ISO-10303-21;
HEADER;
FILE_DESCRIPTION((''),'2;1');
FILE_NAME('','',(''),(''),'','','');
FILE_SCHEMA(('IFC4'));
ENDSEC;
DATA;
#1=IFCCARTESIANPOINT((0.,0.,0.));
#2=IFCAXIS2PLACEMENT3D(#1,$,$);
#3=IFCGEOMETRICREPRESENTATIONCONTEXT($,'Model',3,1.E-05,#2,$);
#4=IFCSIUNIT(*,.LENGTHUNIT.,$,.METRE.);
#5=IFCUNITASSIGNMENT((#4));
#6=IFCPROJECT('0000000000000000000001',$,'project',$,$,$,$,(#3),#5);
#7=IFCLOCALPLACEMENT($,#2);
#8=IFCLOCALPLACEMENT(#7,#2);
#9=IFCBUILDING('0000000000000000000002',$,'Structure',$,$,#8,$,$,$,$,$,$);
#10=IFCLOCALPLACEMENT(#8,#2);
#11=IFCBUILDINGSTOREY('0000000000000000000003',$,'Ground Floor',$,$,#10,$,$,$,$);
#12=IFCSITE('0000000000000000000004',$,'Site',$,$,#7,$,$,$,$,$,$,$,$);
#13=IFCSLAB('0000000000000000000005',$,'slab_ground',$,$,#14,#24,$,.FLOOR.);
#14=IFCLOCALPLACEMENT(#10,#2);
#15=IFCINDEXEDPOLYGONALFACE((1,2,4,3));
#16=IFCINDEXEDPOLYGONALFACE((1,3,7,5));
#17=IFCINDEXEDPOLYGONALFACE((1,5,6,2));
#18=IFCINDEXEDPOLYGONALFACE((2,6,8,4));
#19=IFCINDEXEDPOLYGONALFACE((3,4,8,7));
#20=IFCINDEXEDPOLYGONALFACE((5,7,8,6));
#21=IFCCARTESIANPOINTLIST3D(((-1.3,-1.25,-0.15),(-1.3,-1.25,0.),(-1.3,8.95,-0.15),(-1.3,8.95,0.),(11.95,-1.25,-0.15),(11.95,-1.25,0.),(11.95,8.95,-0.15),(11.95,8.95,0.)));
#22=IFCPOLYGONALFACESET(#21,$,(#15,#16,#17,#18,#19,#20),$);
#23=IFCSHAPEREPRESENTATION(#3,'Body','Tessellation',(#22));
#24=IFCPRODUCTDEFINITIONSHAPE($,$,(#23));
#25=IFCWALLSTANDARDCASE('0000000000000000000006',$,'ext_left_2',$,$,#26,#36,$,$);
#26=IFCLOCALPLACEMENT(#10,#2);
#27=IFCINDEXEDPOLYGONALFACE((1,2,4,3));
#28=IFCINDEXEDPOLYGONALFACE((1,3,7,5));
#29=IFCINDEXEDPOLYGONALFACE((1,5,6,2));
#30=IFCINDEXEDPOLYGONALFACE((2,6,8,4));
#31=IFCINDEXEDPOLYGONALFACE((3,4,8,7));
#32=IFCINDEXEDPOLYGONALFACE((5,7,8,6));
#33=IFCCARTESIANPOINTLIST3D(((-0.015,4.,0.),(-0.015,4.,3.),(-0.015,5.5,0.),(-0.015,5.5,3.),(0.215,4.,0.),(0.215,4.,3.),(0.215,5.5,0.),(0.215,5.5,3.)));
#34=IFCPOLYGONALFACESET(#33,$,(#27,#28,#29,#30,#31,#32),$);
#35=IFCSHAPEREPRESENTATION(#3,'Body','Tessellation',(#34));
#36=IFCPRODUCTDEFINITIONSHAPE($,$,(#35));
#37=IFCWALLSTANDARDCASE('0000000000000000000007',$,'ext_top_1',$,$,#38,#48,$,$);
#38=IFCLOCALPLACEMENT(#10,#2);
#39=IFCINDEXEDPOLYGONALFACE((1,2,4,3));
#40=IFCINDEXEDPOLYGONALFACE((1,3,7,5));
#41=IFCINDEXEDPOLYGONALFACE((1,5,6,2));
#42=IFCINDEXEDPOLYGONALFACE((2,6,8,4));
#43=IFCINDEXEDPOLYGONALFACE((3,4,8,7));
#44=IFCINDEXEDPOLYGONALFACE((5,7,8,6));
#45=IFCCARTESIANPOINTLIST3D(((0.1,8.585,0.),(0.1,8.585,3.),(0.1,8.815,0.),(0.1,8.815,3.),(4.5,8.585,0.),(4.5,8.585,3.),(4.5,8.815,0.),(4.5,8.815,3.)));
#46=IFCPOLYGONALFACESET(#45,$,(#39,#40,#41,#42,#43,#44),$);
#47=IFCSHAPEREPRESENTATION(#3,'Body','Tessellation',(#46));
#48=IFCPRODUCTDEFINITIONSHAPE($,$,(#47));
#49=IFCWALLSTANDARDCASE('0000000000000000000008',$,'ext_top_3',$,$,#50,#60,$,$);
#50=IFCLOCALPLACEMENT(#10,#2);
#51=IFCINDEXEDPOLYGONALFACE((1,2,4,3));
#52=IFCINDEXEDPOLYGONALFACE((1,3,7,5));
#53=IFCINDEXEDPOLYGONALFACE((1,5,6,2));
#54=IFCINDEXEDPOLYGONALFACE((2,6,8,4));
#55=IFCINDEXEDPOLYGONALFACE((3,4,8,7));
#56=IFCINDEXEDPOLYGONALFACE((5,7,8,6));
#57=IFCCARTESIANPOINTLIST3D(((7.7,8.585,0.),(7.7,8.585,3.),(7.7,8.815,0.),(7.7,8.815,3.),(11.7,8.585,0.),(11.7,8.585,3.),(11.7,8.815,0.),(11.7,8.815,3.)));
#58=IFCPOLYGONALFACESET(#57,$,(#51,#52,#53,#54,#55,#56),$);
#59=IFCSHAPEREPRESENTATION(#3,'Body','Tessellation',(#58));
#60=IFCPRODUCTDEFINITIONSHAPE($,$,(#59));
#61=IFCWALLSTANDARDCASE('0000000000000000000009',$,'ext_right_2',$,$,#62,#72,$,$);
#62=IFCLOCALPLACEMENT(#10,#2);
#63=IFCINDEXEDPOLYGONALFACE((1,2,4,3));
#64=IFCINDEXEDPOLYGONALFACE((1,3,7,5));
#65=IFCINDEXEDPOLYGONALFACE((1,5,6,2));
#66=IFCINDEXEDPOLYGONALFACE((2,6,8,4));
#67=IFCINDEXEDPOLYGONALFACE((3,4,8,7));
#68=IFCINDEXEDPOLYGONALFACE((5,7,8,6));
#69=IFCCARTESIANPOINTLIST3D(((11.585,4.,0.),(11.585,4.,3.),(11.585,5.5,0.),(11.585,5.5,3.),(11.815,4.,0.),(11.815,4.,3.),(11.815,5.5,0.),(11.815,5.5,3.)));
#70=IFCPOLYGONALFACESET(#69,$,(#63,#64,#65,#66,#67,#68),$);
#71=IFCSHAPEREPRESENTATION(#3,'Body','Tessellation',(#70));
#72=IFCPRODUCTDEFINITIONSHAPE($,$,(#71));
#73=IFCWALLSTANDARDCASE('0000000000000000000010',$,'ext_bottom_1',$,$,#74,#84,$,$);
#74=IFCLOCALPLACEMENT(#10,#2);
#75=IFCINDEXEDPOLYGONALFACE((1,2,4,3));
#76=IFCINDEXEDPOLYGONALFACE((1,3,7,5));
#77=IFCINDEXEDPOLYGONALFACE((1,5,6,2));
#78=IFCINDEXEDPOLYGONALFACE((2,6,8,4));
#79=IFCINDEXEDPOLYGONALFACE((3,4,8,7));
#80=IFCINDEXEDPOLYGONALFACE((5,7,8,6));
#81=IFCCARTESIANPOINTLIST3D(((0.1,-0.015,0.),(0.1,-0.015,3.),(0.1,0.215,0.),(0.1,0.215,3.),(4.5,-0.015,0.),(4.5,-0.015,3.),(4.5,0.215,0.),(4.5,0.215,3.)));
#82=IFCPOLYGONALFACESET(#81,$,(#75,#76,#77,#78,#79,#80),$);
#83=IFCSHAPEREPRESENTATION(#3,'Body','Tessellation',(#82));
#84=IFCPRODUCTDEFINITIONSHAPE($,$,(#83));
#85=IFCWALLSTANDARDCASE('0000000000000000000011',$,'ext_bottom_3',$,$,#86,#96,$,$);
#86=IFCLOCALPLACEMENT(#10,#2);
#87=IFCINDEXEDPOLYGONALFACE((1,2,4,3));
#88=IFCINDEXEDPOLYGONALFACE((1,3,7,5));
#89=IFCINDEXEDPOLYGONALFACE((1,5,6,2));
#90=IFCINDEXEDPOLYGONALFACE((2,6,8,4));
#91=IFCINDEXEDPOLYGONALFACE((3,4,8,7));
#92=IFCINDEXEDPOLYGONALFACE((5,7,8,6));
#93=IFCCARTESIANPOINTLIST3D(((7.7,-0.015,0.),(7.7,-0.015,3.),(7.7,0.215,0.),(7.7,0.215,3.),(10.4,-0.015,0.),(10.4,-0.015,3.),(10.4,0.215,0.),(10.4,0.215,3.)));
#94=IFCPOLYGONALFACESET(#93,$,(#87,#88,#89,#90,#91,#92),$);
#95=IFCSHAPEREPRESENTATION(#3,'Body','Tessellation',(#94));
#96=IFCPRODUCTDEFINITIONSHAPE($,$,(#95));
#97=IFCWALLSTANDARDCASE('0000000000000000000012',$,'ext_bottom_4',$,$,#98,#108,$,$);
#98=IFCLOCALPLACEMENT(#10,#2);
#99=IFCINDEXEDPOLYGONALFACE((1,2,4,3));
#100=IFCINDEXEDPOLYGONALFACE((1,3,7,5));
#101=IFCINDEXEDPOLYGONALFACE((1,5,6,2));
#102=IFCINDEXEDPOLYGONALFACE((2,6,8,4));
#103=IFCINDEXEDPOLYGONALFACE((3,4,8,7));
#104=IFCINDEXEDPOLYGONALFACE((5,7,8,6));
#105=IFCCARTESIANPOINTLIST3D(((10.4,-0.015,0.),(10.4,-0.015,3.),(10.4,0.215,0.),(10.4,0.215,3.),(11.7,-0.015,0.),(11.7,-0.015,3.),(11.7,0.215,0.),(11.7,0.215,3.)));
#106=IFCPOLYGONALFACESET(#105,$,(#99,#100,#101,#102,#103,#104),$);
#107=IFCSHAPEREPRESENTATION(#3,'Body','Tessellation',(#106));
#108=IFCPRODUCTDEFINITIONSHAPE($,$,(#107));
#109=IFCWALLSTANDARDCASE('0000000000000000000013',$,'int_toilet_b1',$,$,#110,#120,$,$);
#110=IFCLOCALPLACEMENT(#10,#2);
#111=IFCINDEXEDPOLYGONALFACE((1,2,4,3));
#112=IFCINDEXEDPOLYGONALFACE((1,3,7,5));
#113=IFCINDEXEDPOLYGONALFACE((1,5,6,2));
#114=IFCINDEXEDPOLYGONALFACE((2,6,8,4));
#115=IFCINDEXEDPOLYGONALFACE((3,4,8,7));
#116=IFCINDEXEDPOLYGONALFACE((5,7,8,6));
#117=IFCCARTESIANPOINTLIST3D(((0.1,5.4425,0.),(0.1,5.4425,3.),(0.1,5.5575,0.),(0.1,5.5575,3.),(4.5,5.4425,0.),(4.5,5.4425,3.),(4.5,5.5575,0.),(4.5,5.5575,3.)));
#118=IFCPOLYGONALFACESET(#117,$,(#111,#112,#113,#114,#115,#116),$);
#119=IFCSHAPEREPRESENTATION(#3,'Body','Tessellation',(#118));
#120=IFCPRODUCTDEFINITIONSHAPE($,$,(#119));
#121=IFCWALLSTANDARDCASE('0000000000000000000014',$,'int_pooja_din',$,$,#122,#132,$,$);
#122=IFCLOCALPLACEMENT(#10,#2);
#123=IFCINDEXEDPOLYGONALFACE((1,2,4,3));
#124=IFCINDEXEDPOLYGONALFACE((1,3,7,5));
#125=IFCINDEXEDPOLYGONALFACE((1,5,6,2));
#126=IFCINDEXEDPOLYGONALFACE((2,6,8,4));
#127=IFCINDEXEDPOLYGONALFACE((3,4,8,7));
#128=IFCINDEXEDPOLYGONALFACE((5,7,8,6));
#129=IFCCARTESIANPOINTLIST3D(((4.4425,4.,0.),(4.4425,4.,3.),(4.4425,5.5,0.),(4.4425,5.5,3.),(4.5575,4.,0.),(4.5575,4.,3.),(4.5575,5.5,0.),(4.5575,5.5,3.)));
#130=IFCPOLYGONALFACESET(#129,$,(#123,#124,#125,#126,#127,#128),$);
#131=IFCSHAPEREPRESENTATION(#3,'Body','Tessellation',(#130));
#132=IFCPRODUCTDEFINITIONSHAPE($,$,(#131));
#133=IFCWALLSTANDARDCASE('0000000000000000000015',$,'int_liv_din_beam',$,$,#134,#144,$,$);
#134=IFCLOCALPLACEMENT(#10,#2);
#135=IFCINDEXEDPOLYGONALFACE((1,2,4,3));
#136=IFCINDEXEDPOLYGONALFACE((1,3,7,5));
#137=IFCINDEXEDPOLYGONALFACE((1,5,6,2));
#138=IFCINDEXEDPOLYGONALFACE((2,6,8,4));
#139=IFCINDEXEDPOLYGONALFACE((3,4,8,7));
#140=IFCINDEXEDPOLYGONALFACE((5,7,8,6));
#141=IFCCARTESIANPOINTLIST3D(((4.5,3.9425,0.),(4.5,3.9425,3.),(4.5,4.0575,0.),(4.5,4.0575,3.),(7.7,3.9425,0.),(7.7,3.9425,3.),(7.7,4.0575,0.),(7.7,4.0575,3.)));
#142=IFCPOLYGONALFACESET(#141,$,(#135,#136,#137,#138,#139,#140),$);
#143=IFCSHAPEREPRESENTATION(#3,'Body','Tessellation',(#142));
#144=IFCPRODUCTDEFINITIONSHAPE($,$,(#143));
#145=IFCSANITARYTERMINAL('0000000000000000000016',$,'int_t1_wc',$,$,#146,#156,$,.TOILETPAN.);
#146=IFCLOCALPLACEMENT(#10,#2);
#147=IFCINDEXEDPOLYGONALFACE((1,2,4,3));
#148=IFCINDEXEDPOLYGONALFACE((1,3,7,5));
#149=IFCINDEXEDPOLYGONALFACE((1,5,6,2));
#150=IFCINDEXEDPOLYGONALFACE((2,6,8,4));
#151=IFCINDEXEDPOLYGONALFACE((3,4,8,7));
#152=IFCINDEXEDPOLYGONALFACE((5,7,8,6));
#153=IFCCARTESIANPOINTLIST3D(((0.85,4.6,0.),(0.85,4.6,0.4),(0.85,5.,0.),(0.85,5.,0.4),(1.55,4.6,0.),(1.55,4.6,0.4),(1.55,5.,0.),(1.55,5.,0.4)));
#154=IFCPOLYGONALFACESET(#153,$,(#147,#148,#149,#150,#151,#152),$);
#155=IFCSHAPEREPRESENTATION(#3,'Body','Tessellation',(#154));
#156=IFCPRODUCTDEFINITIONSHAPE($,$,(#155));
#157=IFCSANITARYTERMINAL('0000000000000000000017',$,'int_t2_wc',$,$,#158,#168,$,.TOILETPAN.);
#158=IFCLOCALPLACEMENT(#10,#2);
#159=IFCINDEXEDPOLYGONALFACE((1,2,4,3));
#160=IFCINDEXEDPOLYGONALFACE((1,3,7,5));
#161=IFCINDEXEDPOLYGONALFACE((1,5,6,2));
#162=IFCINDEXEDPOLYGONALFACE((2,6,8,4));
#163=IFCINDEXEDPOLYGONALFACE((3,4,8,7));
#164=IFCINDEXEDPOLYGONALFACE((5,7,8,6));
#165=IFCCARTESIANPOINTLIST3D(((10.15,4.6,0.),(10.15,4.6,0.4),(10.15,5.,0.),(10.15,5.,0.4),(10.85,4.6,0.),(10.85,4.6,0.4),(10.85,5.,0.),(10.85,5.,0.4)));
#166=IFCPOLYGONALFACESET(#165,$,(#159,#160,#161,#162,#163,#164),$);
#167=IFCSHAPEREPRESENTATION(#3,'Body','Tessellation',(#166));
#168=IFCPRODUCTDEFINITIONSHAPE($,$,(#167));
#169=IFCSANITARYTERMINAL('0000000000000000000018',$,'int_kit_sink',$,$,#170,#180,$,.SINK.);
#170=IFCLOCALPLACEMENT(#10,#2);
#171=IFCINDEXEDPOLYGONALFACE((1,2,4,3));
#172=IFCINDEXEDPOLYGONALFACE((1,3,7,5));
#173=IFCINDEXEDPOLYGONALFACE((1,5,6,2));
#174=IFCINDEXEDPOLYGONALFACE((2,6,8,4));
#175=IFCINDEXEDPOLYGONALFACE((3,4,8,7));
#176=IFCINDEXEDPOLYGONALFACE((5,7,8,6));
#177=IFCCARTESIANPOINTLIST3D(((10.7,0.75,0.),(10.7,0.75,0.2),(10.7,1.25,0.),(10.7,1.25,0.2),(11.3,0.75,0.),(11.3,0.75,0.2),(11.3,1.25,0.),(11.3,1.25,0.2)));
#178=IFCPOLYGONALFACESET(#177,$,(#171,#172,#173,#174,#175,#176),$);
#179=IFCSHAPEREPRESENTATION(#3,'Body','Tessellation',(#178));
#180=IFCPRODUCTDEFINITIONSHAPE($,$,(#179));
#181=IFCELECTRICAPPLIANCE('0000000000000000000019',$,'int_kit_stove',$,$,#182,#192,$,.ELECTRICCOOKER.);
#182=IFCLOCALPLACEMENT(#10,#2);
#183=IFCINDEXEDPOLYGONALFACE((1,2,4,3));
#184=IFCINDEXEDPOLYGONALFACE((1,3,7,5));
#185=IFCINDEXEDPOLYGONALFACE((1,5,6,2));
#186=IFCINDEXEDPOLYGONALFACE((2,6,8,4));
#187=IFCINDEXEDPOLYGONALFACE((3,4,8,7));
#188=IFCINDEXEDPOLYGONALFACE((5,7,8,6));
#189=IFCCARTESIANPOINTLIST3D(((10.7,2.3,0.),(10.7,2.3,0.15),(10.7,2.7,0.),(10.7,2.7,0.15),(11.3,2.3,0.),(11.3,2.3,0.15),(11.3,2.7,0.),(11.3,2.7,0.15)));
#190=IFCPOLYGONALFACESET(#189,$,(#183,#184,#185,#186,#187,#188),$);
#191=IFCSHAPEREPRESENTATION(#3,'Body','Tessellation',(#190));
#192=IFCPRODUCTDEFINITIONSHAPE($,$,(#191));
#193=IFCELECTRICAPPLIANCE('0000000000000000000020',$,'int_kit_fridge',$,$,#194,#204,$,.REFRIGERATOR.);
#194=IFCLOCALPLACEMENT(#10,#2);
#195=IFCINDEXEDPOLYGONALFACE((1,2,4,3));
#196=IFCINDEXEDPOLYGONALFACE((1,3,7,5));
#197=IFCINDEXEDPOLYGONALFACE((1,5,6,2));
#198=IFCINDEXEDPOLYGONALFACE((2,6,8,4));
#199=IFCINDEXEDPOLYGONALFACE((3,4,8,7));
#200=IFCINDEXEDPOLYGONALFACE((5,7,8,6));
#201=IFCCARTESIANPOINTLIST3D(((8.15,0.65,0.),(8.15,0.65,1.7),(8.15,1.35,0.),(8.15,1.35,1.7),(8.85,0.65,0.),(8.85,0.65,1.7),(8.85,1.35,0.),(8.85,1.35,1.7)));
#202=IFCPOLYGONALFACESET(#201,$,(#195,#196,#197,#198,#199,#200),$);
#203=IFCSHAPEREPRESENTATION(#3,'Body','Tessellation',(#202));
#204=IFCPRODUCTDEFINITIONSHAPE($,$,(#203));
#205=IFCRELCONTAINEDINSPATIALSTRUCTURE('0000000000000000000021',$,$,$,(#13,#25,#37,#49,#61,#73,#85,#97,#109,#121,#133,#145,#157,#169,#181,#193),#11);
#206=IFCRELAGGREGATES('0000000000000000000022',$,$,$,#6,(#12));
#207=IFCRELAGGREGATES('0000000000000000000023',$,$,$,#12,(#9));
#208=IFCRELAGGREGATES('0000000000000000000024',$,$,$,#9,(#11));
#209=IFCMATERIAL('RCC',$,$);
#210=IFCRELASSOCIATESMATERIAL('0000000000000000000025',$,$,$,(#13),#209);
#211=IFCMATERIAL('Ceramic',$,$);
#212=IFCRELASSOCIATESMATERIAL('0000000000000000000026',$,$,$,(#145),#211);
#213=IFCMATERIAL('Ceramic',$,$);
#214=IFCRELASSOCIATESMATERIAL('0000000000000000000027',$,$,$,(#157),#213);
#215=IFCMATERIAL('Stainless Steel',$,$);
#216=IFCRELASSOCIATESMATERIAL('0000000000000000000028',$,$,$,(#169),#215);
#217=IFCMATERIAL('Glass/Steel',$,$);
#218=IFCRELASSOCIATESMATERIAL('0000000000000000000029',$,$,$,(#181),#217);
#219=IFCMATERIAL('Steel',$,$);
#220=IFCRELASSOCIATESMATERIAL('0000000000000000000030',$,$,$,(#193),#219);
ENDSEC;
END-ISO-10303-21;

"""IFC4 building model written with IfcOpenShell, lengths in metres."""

from ifc_helpers import new_model, si_unit, frame, origin, place, context, project, spatial, polyline, outline, extrude, material, element, save


model = new_model("IFC4")

# Units and contexts
model_context = context("Model", 3, precision=1e-05, world=origin())
ifc_project = project(units=[si_unit("LENGTHUNIT", "METRE")], contexts=[model_context])

# Site, building, storey
site_placement = place(None, origin())
site = spatial("IfcSite", under=ifc_project, at=site_placement, Name="Site")
building_placement = place(site_placement, origin())
building = spatial("IfcBuilding", under=site, at=building_placement, Name="Structure")
storey_placement = place(building_placement, origin())
storey = spatial("IfcBuildingStorey", under=building, at=storey_placement, Name="Ground Floor")

# Slab
ifc_material_1 = material(Name="RCC")
slab_placement = place(storey_placement, frame((0.0, 0.0, -0.15)))
element("IfcSlab", 1, at=slab_placement, inside=storey, material=ifc_material_1, Name="slab_ground", PredefinedType="FLOOR", context=model_context, shape_type="SweptSolid", body=[
    extrude(outline(polyline([(-1.3, -1.25), (11.95, -1.25), (11.95, 8.95), (-1.3, 8.95), (-1.3, -1.25)])), origin(), (0.0, 0.0, 1.0), 0.15),
])

# Walls
wall_1_placement = place(storey_placement, frame((0.1, 4.0, 0.0), x_axis=(0.0, 1.0, 0.0)))
element("IfcWallStandardCase", 2, at=wall_1_placement, inside=storey, Name="ext_left_2", context=model_context, shape_type="SweptSolid", body=[
    extrude(outline(polyline([(0.0, -0.115), (1.5, -0.115), (1.5, 0.115), (0.0, 0.115), (0.0, -0.115)])), origin(), (0.0, 0.0, 1.0), 3.0),
])
wall_2_placement = place(storey_placement, frame((0.1, 8.7, 0.0), x_axis=(1.0, 0.0, 0.0)))
element("IfcWallStandardCase", 3, at=wall_2_placement, inside=storey, Name="ext_top_1", context=model_context, shape_type="SweptSolid", body=[
    extrude(outline(polyline([(0.0, -0.115), (4.4, -0.115), (4.4, 0.115), (0.0, 0.115), (0.0, -0.115)])), origin(), (0.0, 0.0, 1.0), 3.0),
])
wall_3_placement = place(storey_placement, frame((7.7, 8.7, 0.0), x_axis=(1.0, 0.0, 0.0)))
element("IfcWallStandardCase", 4, at=wall_3_placement, inside=storey, Name="ext_top_3", context=model_context, shape_type="SweptSolid", body=[
    extrude(outline(polyline([(0.0, -0.115), (4.0, -0.115), (4.0, 0.115), (0.0, 0.115), (0.0, -0.115)])), origin(), (0.0, 0.0, 1.0), 3.0),
])
wall_4_placement = place(storey_placement, frame((11.7, 5.5, 0.0), x_axis=(0.0, -1.0, 0.0)))
element("IfcWallStandardCase", 5, at=wall_4_placement, inside=storey, Name="ext_right_2", context=model_context, shape_type="SweptSolid", body=[
    extrude(outline(polyline([(0.0, -0.115), (1.5, -0.115), (1.5, 0.115), (0.0, 0.115), (0.0, -0.115)])), origin(), (0.0, 0.0, 1.0), 3.0),
])
wall_5_placement = place(storey_placement, frame((0.1, 0.1, 0.0), x_axis=(1.0, 0.0, 0.0)))
element("IfcWallStandardCase", 6, at=wall_5_placement, inside=storey, Name="ext_bottom_1", context=model_context, shape_type="SweptSolid", body=[
    extrude(outline(polyline([(0.0, -0.115), (4.4, -0.115), (4.4, 0.115), (0.0, 0.115), (0.0, -0.115)])), origin(), (0.0, 0.0, 1.0), 3.0),
])
wall_6_placement = place(storey_placement, frame((7.7, 0.1, 0.0), x_axis=(1.0, 0.0, 0.0)))
element("IfcWallStandardCase", 7, at=wall_6_placement, inside=storey, Name="ext_bottom_3", context=model_context, shape_type="SweptSolid", body=[
    extrude(outline(polyline([(0.0, -0.115), (2.7, -0.115), (2.7, 0.115), (0.0, 0.115), (0.0, -0.115)])), origin(), (0.0, 0.0, 1.0), 3.0),
])
wall_7_placement = place(storey_placement, frame((10.4, 0.1, 0.0), x_axis=(1.0, 0.0, 0.0)))
element("IfcWallStandardCase", 8, at=wall_7_placement, inside=storey, Name="ext_bottom_4", context=model_context, shape_type="SweptSolid", body=[
    extrude(outline(polyline([(0.0, -0.115), (1.3, -0.115), (1.3, 0.115), (0.0, 0.115), (0.0, -0.115)])), origin(), (0.0, 0.0, 1.0), 3.0),
])
wall_8_placement = place(storey_placement, frame((0.1, 5.5, 0.0), x_axis=(1.0, 0.0, 0.0)))
element("IfcWallStandardCase", 9, at=wall_8_placement, inside=storey, Name="int_toilet_b1", context=model_context, shape_type="SweptSolid", body=[
    extrude(outline(polyline([(0.0, -0.0575), (4.4, -0.0575), (4.4, 0.0575), (0.0, 0.0575), (0.0, -0.0575)])), origin(), (0.0, 0.0, 1.0), 3.0),
])
wall_9_placement = place(storey_placement, frame((4.5, 4.0, 0.0), x_axis=(0.0, 1.0, 0.0)))
element("IfcWallStandardCase", 10, at=wall_9_placement, inside=storey, Name="int_pooja_din", context=model_context, shape_type="SweptSolid", body=[
    extrude(outline(polyline([(0.0, -0.0575), (1.5, -0.0575), (1.5, 0.0575), (0.0, 0.0575), (0.0, -0.0575)])), origin(), (0.0, 0.0, 1.0), 3.0),
])
wall_10_placement = place(storey_placement, frame((4.5, 4.0, 0.0), x_axis=(1.0, 0.0, 0.0)))
element("IfcWallStandardCase", 11, at=wall_10_placement, inside=storey, Name="int_liv_din_beam", context=model_context, shape_type="SweptSolid", body=[
    extrude(outline(polyline([(0.0, -0.0575), (3.2, -0.0575), (3.2, 0.0575), (0.0, 0.0575), (0.0, -0.0575)])), origin(), (0.0, 0.0, 1.0), 3.0),
])

# Sanitary terminals
ifc_material_2 = material(Name="Ceramic")
sanitary_terminal_1_placement = place(storey_placement, frame((1.2, 4.8, 0.0)))
element("IfcSanitaryTerminal", 12, at=sanitary_terminal_1_placement, inside=storey, material=ifc_material_2, Name="int_t1_wc", PredefinedType="TOILETPAN", context=model_context, shape_type="SweptSolid", body=[
    extrude(outline(polyline([(-0.35, -0.2), (0.35, -0.2), (0.35, 0.2), (-0.35, 0.2), (-0.35, -0.2)])), origin(), (0.0, 0.0, 1.0), 0.4),
])
ifc_material_3 = material(Name="Ceramic")
sanitary_terminal_2_placement = place(storey_placement, frame((10.5, 4.8, 0.0)))
element("IfcSanitaryTerminal", 13, at=sanitary_terminal_2_placement, inside=storey, material=ifc_material_3, Name="int_t2_wc", PredefinedType="TOILETPAN", context=model_context, shape_type="SweptSolid", body=[
    extrude(outline(polyline([(-0.35, -0.2), (0.35, -0.2), (0.35, 0.2), (-0.35, 0.2), (-0.35, -0.2)])), origin(), (0.0, 0.0, 1.0), 0.4),
])
ifc_material_4 = material(Name="Stainless Steel")
sanitary_terminal_3_placement = place(storey_placement, frame((11.0, 1.0, 0.0)))
element("IfcSanitaryTerminal", 14, at=sanitary_terminal_3_placement, inside=storey, material=ifc_material_4, Name="int_kit_sink", PredefinedType="SINK", context=model_context, shape_type="SweptSolid", body=[
    extrude(outline(polyline([(-0.3, -0.25), (0.3, -0.25), (0.3, 0.25), (-0.3, 0.25), (-0.3, -0.25)])), origin(), (0.0, 0.0, 1.0), 0.2),
])

# Electric appliances
ifc_material_5 = material(Name="Glass/Steel")
electric_appliance_1_placement = place(storey_placement, frame((11.0, 2.5, 0.0)))
element("IfcElectricAppliance", 15, at=electric_appliance_1_placement, inside=storey, material=ifc_material_5, Name="int_kit_stove", PredefinedType="ELECTRICCOOKER", context=model_context, shape_type="SweptSolid", body=[
    extrude(outline(polyline([(-0.3, -0.2), (0.3, -0.2), (0.3, 0.2), (-0.3, 0.2), (-0.3, -0.2)])), origin(), (0.0, 0.0, 1.0), 0.15),
])
ifc_material_6 = material(Name="Steel")
electric_appliance_2_placement = place(storey_placement, frame((8.5, 1.0, 0.0)))
element("IfcElectricAppliance", 16, at=electric_appliance_2_placement, inside=storey, material=ifc_material_6, Name="int_kit_fridge", PredefinedType="REFRIGERATOR", context=model_context, shape_type="SweptSolid", body=[
    extrude(outline(polyline([(-0.35, -0.35), (0.35, -0.35), (0.35, 0.35), (-0.35, 0.35), (-0.35, -0.35)])), origin(), (0.0, 0.0, 1.0), 1.7),
])

save(model, "model.ifc")
